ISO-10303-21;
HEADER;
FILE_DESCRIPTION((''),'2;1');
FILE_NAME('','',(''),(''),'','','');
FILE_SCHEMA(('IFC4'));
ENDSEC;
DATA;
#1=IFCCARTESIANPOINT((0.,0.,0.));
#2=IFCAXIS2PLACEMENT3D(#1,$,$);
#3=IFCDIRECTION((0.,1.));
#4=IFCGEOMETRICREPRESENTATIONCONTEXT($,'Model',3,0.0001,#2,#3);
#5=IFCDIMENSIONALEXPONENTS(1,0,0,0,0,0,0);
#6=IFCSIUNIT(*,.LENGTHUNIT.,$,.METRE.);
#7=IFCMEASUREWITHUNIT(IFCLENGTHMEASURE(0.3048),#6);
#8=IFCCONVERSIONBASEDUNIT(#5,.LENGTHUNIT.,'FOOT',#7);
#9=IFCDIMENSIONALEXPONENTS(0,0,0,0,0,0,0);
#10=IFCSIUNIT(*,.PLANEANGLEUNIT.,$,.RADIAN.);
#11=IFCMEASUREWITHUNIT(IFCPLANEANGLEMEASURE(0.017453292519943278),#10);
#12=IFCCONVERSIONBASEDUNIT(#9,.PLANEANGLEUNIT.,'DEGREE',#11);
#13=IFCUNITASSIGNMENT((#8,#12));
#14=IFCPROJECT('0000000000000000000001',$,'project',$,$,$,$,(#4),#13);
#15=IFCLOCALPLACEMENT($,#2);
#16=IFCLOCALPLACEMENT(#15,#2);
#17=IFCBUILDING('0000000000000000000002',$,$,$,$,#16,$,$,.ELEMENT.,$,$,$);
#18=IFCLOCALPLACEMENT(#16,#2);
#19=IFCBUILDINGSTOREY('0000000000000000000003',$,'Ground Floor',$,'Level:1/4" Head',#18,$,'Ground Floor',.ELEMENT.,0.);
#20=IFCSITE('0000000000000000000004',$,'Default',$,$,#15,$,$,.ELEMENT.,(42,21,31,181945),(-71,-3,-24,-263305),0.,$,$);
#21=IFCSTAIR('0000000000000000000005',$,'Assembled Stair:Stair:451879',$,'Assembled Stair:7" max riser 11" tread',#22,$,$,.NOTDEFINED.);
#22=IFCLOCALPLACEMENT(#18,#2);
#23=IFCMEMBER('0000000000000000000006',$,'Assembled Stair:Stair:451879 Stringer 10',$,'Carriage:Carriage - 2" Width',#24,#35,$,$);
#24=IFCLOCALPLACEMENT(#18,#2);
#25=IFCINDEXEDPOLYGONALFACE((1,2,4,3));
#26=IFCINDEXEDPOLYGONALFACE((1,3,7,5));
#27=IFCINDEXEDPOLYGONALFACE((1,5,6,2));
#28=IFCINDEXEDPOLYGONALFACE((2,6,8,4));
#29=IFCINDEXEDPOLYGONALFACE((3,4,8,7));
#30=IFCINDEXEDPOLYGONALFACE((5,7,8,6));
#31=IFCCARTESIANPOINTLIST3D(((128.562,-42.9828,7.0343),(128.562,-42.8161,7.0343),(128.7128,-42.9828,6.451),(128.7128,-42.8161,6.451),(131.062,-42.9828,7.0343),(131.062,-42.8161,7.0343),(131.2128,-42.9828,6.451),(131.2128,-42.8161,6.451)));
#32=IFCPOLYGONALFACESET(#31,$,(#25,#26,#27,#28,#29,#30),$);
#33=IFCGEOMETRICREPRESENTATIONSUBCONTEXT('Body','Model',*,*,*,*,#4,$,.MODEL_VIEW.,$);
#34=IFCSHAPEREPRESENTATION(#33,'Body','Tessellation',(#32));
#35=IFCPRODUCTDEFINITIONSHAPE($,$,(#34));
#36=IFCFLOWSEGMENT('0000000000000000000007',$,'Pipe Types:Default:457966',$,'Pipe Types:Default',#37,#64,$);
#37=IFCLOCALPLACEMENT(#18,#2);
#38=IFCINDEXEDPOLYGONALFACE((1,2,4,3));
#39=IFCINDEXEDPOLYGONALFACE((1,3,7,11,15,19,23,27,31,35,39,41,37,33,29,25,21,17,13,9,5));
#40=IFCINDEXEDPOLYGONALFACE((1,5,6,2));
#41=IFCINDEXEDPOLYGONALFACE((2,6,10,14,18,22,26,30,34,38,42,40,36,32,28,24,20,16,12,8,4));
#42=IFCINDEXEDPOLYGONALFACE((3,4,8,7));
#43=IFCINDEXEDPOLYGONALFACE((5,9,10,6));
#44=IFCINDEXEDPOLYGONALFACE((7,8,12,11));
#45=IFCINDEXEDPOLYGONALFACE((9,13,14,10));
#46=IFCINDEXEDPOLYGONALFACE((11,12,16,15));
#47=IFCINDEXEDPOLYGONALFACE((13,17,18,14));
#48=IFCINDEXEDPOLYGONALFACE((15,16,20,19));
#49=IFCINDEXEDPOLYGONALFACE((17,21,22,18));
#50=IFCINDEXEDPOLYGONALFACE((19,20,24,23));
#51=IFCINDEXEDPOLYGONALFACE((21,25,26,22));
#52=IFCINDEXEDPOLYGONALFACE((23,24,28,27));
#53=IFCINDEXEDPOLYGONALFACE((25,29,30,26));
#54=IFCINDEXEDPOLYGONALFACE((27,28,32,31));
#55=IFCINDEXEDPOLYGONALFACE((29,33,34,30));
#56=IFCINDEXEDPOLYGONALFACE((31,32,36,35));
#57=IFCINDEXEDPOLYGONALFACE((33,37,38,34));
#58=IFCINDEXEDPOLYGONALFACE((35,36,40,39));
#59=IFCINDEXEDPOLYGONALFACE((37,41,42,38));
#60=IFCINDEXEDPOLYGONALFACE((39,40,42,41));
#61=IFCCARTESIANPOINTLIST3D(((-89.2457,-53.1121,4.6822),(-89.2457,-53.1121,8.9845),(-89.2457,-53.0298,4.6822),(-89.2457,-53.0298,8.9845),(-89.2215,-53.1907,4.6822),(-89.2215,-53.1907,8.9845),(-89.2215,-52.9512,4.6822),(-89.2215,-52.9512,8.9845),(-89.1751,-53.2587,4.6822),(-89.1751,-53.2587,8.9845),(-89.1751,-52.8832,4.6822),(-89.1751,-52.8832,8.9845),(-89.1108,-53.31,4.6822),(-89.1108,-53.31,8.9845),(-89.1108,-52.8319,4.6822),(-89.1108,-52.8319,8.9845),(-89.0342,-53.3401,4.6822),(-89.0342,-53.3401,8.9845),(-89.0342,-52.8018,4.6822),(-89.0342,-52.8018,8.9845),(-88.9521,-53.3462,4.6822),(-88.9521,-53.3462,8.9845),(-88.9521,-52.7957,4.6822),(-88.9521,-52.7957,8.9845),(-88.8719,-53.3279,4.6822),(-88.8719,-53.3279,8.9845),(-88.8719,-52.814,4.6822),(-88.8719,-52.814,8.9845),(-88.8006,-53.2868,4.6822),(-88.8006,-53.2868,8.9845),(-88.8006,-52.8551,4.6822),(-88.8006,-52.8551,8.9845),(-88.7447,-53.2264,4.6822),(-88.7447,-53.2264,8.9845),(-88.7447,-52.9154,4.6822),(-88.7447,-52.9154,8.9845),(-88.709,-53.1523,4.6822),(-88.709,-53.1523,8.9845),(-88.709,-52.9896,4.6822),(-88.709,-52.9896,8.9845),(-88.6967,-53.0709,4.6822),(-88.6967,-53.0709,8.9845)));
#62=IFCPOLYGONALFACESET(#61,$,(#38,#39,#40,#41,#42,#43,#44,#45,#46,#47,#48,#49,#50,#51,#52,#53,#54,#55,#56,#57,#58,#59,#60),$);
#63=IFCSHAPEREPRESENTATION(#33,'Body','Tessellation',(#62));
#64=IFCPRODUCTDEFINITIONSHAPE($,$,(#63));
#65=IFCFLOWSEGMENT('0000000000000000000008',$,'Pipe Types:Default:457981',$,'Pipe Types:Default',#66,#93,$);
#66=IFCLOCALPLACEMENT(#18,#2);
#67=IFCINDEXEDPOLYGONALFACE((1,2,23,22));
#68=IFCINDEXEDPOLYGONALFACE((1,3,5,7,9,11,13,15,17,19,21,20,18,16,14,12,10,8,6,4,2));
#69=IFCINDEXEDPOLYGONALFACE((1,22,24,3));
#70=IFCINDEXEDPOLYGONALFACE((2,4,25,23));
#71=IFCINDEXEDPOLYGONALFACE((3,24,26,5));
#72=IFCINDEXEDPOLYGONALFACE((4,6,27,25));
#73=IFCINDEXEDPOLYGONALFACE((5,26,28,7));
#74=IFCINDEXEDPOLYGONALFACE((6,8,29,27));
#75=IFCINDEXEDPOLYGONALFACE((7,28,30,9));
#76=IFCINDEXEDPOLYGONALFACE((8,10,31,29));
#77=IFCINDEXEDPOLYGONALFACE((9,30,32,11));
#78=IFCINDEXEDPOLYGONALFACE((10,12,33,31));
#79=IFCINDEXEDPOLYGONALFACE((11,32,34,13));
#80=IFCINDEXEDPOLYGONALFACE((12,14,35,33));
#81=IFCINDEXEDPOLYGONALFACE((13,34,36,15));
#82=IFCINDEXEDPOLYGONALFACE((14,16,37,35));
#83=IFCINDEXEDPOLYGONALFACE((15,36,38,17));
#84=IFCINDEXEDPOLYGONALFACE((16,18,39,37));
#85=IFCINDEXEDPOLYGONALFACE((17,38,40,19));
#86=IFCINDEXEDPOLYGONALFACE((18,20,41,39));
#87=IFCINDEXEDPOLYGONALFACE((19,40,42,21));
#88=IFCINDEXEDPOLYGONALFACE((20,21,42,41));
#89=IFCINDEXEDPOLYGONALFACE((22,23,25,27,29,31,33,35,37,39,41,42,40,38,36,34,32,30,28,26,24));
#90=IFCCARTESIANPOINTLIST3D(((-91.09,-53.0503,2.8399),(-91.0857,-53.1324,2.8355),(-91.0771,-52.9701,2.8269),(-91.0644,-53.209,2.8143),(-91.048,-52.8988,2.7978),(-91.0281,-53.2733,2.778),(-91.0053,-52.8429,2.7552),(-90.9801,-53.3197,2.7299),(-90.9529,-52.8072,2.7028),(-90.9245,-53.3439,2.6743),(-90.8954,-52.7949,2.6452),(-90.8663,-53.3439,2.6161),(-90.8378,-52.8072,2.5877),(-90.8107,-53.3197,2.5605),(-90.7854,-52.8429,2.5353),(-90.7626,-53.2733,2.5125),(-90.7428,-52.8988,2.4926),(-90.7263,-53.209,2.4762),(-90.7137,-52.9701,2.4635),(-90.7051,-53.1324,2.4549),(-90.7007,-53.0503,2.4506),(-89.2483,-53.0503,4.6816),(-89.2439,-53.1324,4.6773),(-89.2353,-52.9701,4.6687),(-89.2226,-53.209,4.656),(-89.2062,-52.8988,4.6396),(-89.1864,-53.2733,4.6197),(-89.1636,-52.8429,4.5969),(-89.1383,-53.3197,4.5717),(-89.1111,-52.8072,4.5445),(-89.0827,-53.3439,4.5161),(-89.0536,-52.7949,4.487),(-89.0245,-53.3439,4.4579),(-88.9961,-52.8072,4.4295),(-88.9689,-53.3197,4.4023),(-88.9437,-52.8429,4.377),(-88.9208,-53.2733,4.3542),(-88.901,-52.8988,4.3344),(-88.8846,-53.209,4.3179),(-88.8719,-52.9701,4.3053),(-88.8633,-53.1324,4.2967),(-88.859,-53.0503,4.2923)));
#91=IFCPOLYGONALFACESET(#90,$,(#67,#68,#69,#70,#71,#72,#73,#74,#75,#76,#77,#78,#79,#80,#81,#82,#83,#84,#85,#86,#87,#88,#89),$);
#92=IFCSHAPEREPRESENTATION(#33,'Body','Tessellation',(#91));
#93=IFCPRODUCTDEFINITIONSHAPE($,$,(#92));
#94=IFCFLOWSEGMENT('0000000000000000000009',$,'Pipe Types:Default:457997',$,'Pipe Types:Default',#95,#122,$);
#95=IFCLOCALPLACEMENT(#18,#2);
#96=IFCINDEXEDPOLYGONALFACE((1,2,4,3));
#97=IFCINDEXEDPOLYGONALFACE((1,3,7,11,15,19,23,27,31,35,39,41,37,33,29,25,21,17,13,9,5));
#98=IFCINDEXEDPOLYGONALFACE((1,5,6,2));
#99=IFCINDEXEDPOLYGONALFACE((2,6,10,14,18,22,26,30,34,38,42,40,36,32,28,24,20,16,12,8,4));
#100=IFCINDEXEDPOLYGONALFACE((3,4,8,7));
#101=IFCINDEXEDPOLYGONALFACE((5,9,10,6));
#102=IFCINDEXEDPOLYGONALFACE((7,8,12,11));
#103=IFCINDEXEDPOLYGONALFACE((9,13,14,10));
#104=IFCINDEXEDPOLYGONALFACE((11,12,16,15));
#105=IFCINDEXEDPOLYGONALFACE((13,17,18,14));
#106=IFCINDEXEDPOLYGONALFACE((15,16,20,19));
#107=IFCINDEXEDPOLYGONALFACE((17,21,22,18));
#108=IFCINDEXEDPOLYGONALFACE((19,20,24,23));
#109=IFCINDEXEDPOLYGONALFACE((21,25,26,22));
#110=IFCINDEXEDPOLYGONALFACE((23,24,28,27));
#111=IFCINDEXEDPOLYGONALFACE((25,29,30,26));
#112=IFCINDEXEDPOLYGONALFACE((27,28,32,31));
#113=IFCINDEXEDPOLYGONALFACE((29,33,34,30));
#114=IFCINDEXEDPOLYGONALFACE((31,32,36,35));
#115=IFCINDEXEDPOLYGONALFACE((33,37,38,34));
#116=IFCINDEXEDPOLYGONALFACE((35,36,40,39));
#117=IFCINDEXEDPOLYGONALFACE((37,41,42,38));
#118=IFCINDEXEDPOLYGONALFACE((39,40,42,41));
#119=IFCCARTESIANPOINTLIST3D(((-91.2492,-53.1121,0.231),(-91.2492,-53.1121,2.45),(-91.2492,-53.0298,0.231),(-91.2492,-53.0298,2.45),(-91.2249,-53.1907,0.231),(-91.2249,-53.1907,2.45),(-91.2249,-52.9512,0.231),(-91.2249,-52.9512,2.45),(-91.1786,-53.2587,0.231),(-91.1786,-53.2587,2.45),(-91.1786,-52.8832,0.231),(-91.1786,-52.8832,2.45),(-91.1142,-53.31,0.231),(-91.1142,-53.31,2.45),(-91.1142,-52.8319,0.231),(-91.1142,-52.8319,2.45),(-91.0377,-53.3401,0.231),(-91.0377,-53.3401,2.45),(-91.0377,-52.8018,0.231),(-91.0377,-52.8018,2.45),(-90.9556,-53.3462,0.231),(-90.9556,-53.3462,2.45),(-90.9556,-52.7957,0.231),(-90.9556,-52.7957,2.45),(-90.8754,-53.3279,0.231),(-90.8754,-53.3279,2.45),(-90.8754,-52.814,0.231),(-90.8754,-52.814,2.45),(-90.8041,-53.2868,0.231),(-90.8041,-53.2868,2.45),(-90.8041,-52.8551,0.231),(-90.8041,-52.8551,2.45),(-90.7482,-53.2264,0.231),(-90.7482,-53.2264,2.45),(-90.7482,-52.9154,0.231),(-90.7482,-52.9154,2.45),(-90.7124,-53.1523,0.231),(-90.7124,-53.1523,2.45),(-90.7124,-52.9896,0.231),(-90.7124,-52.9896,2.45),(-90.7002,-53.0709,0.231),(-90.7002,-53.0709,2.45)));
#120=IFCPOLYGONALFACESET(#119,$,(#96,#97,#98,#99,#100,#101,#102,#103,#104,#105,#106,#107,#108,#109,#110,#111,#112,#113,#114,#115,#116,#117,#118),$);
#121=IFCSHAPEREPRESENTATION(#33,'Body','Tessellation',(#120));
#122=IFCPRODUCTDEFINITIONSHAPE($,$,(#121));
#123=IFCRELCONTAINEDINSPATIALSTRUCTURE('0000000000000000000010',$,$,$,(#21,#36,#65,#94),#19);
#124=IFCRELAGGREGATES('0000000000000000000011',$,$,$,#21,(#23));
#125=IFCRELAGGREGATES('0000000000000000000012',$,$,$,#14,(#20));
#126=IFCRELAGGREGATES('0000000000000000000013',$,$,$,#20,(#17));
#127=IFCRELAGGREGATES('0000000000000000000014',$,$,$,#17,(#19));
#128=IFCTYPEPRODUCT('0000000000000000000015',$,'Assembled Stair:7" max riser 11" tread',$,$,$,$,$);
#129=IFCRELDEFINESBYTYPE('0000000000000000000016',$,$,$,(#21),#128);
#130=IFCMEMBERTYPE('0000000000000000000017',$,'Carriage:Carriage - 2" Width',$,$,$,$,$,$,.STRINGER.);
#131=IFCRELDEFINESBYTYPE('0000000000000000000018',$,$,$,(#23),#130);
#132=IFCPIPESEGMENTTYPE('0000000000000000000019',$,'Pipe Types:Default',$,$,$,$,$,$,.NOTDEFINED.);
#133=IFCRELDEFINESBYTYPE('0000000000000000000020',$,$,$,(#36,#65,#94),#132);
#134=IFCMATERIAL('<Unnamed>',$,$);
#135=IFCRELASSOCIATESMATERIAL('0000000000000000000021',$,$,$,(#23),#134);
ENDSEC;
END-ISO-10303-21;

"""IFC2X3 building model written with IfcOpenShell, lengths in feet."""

from ifc_helpers import new_model, entity, si_unit, converted_unit, direction, frame, frame_2d, origin, origin_2d_with_axis, place, context, subcontext, project, spatial, polyline, circle, outline, extrude, material, type_object, element, aggregate, save


model = new_model("IFC2X3")

# Units and contexts
model_context = context("Model", 3, precision=0.0001, world=origin(), true_north=direction((0.0, 1.0)))
body_context = subcontext(model_context, "Body", "Model", "MODEL_VIEW")
ifc_project = project(units=[converted_unit("LENGTHUNIT", "FOOT", entity("IfcLengthMeasure", 0.3048), si_unit("LENGTHUNIT", "METRE"), dimensions=[1, 0, 0, 0, 0, 0, 0]), converted_unit("PLANEANGLEUNIT", "DEGREE", entity("IfcPlaneAngleMeasure", 0.017453292519943278), si_unit("PLANEANGLEUNIT", "RADIAN"), dimensions=[0, 0, 0, 0, 0, 0, 0])], contexts=[model_context])

# Site, building, storey
site_placement = place(None, origin())
site = spatial("IfcSite", under=ifc_project, at=site_placement, Name="Default", CompositionType="ELEMENT", RefLatitude=(42, 21, 31, 181945), RefLongitude=(-71, -3, -24, -263305), RefElevation=0.0)
building_placement = place(site_placement, origin())
building = spatial("IfcBuilding", under=site, at=building_placement, CompositionType="ELEMENT")
storey_placement = place(building_placement, origin())
storey = spatial("IfcBuildingStorey", under=building, at=storey_placement, Name="Ground Floor", ObjectType="Level:1/4\" Head", LongName="Ground Floor", CompositionType="ELEMENT", Elevation=0.0)

# Stair, member
type_product_1 = type_object("IfcTypeProduct", Name="Assembled Stair:7\" max riser 11\" tread")
stair_1_placement = place(storey_placement, origin())
stair_1 = element("IfcStair", 1, at=stair_1_placement, inside=storey, type_object=type_product_1, Name="Assembled Stair:Stair:451879", ObjectType="Assembled Stair:7\" max riser 11\" tread", ShapeType="NOTDEFINED")
ifc_material_1 = material(Name="<Unnamed>")
member_type = type_object("IfcMemberType", Name="Carriage:Carriage - 2\" Width", PredefinedType="STRINGER")
member_1_placement = place(stair_1_placement, origin())
member_1 = element("IfcMember", 2, at=member_1_placement, type_object=member_type, material=ifc_material_1, Name="Assembled Stair:Stair:451879 Stringer 10", ObjectType="Carriage:Carriage - 2\" Width", context=body_context, shape_type="SweptSolid", body=[
    extrude(outline(polyline([(0.0115, -1.2102), (0.614, -1.2102), (-0.0115, 1.2102), (-0.614, 1.2102), (0.0115, -1.2102)])), frame((129.8874, -42.9828, 6.7426), z_axis=(0.0, 1.0, 0.0), x_axis=(-0.250236, 0.0, 0.968185)), (0.0, 0.0, 1.0), 0.1667),
])
aggregate(stair_1, [member_1])

# Flow segments
pipe_segment_type = type_object("IfcPipeSegmentType", Name="Pipe Types:Default", PredefinedType="NOTDEFINED")
flow_segment_1_placement = place(storey_placement, origin())
element("IfcFlowSegment", 3, at=flow_segment_1_placement, inside=storey, type_object=pipe_segment_type, Name="Pipe Types:Default:457966", ObjectType="Pipe Types:Default", context=body_context, shape_type="SweptSolid", body=[
    extrude(circle(Radius=0.276, at=origin_2d_with_axis()), frame((-88.9728, -53.0709, 4.6822)), (0.0, 0.0, 1.0), 4.3023),
])
flow_segment_2_placement = place(storey_placement, origin())
element("IfcFlowSegment", 4, at=flow_segment_2_placement, inside=storey, type_object=pipe_segment_type, Name="Pipe Types:Default:457981", ObjectType="Pipe Types:Default", context=body_context, shape_type="SweptSolid", body=[
    extrude(circle(Radius=0.276, at=frame_2d((0.0, 0.0), x_axis=(1.0, 0.0))), frame((-90.8954, -53.0709, 2.6452), z_axis=(0.707107, 0.0, 0.707107), x_axis=(0.0, 1.0, 0.0)), (0.0, 0.0, 1.0), 2.6047),
])
flow_segment_3_placement = place(storey_placement, origin())
element("IfcFlowSegment", 5, at=flow_segment_3_placement, inside=storey, type_object=pipe_segment_type, Name="Pipe Types:Default:457997", ObjectType="Pipe Types:Default", context=body_context, shape_type="SweptSolid", body=[
    extrude(circle(Radius=0.276, at=origin_2d_with_axis()), frame((-90.9762, -53.0709, 0.231)), (0.0, 0.0, 1.0), 2.219),
])

save(model, "model.ifc")
